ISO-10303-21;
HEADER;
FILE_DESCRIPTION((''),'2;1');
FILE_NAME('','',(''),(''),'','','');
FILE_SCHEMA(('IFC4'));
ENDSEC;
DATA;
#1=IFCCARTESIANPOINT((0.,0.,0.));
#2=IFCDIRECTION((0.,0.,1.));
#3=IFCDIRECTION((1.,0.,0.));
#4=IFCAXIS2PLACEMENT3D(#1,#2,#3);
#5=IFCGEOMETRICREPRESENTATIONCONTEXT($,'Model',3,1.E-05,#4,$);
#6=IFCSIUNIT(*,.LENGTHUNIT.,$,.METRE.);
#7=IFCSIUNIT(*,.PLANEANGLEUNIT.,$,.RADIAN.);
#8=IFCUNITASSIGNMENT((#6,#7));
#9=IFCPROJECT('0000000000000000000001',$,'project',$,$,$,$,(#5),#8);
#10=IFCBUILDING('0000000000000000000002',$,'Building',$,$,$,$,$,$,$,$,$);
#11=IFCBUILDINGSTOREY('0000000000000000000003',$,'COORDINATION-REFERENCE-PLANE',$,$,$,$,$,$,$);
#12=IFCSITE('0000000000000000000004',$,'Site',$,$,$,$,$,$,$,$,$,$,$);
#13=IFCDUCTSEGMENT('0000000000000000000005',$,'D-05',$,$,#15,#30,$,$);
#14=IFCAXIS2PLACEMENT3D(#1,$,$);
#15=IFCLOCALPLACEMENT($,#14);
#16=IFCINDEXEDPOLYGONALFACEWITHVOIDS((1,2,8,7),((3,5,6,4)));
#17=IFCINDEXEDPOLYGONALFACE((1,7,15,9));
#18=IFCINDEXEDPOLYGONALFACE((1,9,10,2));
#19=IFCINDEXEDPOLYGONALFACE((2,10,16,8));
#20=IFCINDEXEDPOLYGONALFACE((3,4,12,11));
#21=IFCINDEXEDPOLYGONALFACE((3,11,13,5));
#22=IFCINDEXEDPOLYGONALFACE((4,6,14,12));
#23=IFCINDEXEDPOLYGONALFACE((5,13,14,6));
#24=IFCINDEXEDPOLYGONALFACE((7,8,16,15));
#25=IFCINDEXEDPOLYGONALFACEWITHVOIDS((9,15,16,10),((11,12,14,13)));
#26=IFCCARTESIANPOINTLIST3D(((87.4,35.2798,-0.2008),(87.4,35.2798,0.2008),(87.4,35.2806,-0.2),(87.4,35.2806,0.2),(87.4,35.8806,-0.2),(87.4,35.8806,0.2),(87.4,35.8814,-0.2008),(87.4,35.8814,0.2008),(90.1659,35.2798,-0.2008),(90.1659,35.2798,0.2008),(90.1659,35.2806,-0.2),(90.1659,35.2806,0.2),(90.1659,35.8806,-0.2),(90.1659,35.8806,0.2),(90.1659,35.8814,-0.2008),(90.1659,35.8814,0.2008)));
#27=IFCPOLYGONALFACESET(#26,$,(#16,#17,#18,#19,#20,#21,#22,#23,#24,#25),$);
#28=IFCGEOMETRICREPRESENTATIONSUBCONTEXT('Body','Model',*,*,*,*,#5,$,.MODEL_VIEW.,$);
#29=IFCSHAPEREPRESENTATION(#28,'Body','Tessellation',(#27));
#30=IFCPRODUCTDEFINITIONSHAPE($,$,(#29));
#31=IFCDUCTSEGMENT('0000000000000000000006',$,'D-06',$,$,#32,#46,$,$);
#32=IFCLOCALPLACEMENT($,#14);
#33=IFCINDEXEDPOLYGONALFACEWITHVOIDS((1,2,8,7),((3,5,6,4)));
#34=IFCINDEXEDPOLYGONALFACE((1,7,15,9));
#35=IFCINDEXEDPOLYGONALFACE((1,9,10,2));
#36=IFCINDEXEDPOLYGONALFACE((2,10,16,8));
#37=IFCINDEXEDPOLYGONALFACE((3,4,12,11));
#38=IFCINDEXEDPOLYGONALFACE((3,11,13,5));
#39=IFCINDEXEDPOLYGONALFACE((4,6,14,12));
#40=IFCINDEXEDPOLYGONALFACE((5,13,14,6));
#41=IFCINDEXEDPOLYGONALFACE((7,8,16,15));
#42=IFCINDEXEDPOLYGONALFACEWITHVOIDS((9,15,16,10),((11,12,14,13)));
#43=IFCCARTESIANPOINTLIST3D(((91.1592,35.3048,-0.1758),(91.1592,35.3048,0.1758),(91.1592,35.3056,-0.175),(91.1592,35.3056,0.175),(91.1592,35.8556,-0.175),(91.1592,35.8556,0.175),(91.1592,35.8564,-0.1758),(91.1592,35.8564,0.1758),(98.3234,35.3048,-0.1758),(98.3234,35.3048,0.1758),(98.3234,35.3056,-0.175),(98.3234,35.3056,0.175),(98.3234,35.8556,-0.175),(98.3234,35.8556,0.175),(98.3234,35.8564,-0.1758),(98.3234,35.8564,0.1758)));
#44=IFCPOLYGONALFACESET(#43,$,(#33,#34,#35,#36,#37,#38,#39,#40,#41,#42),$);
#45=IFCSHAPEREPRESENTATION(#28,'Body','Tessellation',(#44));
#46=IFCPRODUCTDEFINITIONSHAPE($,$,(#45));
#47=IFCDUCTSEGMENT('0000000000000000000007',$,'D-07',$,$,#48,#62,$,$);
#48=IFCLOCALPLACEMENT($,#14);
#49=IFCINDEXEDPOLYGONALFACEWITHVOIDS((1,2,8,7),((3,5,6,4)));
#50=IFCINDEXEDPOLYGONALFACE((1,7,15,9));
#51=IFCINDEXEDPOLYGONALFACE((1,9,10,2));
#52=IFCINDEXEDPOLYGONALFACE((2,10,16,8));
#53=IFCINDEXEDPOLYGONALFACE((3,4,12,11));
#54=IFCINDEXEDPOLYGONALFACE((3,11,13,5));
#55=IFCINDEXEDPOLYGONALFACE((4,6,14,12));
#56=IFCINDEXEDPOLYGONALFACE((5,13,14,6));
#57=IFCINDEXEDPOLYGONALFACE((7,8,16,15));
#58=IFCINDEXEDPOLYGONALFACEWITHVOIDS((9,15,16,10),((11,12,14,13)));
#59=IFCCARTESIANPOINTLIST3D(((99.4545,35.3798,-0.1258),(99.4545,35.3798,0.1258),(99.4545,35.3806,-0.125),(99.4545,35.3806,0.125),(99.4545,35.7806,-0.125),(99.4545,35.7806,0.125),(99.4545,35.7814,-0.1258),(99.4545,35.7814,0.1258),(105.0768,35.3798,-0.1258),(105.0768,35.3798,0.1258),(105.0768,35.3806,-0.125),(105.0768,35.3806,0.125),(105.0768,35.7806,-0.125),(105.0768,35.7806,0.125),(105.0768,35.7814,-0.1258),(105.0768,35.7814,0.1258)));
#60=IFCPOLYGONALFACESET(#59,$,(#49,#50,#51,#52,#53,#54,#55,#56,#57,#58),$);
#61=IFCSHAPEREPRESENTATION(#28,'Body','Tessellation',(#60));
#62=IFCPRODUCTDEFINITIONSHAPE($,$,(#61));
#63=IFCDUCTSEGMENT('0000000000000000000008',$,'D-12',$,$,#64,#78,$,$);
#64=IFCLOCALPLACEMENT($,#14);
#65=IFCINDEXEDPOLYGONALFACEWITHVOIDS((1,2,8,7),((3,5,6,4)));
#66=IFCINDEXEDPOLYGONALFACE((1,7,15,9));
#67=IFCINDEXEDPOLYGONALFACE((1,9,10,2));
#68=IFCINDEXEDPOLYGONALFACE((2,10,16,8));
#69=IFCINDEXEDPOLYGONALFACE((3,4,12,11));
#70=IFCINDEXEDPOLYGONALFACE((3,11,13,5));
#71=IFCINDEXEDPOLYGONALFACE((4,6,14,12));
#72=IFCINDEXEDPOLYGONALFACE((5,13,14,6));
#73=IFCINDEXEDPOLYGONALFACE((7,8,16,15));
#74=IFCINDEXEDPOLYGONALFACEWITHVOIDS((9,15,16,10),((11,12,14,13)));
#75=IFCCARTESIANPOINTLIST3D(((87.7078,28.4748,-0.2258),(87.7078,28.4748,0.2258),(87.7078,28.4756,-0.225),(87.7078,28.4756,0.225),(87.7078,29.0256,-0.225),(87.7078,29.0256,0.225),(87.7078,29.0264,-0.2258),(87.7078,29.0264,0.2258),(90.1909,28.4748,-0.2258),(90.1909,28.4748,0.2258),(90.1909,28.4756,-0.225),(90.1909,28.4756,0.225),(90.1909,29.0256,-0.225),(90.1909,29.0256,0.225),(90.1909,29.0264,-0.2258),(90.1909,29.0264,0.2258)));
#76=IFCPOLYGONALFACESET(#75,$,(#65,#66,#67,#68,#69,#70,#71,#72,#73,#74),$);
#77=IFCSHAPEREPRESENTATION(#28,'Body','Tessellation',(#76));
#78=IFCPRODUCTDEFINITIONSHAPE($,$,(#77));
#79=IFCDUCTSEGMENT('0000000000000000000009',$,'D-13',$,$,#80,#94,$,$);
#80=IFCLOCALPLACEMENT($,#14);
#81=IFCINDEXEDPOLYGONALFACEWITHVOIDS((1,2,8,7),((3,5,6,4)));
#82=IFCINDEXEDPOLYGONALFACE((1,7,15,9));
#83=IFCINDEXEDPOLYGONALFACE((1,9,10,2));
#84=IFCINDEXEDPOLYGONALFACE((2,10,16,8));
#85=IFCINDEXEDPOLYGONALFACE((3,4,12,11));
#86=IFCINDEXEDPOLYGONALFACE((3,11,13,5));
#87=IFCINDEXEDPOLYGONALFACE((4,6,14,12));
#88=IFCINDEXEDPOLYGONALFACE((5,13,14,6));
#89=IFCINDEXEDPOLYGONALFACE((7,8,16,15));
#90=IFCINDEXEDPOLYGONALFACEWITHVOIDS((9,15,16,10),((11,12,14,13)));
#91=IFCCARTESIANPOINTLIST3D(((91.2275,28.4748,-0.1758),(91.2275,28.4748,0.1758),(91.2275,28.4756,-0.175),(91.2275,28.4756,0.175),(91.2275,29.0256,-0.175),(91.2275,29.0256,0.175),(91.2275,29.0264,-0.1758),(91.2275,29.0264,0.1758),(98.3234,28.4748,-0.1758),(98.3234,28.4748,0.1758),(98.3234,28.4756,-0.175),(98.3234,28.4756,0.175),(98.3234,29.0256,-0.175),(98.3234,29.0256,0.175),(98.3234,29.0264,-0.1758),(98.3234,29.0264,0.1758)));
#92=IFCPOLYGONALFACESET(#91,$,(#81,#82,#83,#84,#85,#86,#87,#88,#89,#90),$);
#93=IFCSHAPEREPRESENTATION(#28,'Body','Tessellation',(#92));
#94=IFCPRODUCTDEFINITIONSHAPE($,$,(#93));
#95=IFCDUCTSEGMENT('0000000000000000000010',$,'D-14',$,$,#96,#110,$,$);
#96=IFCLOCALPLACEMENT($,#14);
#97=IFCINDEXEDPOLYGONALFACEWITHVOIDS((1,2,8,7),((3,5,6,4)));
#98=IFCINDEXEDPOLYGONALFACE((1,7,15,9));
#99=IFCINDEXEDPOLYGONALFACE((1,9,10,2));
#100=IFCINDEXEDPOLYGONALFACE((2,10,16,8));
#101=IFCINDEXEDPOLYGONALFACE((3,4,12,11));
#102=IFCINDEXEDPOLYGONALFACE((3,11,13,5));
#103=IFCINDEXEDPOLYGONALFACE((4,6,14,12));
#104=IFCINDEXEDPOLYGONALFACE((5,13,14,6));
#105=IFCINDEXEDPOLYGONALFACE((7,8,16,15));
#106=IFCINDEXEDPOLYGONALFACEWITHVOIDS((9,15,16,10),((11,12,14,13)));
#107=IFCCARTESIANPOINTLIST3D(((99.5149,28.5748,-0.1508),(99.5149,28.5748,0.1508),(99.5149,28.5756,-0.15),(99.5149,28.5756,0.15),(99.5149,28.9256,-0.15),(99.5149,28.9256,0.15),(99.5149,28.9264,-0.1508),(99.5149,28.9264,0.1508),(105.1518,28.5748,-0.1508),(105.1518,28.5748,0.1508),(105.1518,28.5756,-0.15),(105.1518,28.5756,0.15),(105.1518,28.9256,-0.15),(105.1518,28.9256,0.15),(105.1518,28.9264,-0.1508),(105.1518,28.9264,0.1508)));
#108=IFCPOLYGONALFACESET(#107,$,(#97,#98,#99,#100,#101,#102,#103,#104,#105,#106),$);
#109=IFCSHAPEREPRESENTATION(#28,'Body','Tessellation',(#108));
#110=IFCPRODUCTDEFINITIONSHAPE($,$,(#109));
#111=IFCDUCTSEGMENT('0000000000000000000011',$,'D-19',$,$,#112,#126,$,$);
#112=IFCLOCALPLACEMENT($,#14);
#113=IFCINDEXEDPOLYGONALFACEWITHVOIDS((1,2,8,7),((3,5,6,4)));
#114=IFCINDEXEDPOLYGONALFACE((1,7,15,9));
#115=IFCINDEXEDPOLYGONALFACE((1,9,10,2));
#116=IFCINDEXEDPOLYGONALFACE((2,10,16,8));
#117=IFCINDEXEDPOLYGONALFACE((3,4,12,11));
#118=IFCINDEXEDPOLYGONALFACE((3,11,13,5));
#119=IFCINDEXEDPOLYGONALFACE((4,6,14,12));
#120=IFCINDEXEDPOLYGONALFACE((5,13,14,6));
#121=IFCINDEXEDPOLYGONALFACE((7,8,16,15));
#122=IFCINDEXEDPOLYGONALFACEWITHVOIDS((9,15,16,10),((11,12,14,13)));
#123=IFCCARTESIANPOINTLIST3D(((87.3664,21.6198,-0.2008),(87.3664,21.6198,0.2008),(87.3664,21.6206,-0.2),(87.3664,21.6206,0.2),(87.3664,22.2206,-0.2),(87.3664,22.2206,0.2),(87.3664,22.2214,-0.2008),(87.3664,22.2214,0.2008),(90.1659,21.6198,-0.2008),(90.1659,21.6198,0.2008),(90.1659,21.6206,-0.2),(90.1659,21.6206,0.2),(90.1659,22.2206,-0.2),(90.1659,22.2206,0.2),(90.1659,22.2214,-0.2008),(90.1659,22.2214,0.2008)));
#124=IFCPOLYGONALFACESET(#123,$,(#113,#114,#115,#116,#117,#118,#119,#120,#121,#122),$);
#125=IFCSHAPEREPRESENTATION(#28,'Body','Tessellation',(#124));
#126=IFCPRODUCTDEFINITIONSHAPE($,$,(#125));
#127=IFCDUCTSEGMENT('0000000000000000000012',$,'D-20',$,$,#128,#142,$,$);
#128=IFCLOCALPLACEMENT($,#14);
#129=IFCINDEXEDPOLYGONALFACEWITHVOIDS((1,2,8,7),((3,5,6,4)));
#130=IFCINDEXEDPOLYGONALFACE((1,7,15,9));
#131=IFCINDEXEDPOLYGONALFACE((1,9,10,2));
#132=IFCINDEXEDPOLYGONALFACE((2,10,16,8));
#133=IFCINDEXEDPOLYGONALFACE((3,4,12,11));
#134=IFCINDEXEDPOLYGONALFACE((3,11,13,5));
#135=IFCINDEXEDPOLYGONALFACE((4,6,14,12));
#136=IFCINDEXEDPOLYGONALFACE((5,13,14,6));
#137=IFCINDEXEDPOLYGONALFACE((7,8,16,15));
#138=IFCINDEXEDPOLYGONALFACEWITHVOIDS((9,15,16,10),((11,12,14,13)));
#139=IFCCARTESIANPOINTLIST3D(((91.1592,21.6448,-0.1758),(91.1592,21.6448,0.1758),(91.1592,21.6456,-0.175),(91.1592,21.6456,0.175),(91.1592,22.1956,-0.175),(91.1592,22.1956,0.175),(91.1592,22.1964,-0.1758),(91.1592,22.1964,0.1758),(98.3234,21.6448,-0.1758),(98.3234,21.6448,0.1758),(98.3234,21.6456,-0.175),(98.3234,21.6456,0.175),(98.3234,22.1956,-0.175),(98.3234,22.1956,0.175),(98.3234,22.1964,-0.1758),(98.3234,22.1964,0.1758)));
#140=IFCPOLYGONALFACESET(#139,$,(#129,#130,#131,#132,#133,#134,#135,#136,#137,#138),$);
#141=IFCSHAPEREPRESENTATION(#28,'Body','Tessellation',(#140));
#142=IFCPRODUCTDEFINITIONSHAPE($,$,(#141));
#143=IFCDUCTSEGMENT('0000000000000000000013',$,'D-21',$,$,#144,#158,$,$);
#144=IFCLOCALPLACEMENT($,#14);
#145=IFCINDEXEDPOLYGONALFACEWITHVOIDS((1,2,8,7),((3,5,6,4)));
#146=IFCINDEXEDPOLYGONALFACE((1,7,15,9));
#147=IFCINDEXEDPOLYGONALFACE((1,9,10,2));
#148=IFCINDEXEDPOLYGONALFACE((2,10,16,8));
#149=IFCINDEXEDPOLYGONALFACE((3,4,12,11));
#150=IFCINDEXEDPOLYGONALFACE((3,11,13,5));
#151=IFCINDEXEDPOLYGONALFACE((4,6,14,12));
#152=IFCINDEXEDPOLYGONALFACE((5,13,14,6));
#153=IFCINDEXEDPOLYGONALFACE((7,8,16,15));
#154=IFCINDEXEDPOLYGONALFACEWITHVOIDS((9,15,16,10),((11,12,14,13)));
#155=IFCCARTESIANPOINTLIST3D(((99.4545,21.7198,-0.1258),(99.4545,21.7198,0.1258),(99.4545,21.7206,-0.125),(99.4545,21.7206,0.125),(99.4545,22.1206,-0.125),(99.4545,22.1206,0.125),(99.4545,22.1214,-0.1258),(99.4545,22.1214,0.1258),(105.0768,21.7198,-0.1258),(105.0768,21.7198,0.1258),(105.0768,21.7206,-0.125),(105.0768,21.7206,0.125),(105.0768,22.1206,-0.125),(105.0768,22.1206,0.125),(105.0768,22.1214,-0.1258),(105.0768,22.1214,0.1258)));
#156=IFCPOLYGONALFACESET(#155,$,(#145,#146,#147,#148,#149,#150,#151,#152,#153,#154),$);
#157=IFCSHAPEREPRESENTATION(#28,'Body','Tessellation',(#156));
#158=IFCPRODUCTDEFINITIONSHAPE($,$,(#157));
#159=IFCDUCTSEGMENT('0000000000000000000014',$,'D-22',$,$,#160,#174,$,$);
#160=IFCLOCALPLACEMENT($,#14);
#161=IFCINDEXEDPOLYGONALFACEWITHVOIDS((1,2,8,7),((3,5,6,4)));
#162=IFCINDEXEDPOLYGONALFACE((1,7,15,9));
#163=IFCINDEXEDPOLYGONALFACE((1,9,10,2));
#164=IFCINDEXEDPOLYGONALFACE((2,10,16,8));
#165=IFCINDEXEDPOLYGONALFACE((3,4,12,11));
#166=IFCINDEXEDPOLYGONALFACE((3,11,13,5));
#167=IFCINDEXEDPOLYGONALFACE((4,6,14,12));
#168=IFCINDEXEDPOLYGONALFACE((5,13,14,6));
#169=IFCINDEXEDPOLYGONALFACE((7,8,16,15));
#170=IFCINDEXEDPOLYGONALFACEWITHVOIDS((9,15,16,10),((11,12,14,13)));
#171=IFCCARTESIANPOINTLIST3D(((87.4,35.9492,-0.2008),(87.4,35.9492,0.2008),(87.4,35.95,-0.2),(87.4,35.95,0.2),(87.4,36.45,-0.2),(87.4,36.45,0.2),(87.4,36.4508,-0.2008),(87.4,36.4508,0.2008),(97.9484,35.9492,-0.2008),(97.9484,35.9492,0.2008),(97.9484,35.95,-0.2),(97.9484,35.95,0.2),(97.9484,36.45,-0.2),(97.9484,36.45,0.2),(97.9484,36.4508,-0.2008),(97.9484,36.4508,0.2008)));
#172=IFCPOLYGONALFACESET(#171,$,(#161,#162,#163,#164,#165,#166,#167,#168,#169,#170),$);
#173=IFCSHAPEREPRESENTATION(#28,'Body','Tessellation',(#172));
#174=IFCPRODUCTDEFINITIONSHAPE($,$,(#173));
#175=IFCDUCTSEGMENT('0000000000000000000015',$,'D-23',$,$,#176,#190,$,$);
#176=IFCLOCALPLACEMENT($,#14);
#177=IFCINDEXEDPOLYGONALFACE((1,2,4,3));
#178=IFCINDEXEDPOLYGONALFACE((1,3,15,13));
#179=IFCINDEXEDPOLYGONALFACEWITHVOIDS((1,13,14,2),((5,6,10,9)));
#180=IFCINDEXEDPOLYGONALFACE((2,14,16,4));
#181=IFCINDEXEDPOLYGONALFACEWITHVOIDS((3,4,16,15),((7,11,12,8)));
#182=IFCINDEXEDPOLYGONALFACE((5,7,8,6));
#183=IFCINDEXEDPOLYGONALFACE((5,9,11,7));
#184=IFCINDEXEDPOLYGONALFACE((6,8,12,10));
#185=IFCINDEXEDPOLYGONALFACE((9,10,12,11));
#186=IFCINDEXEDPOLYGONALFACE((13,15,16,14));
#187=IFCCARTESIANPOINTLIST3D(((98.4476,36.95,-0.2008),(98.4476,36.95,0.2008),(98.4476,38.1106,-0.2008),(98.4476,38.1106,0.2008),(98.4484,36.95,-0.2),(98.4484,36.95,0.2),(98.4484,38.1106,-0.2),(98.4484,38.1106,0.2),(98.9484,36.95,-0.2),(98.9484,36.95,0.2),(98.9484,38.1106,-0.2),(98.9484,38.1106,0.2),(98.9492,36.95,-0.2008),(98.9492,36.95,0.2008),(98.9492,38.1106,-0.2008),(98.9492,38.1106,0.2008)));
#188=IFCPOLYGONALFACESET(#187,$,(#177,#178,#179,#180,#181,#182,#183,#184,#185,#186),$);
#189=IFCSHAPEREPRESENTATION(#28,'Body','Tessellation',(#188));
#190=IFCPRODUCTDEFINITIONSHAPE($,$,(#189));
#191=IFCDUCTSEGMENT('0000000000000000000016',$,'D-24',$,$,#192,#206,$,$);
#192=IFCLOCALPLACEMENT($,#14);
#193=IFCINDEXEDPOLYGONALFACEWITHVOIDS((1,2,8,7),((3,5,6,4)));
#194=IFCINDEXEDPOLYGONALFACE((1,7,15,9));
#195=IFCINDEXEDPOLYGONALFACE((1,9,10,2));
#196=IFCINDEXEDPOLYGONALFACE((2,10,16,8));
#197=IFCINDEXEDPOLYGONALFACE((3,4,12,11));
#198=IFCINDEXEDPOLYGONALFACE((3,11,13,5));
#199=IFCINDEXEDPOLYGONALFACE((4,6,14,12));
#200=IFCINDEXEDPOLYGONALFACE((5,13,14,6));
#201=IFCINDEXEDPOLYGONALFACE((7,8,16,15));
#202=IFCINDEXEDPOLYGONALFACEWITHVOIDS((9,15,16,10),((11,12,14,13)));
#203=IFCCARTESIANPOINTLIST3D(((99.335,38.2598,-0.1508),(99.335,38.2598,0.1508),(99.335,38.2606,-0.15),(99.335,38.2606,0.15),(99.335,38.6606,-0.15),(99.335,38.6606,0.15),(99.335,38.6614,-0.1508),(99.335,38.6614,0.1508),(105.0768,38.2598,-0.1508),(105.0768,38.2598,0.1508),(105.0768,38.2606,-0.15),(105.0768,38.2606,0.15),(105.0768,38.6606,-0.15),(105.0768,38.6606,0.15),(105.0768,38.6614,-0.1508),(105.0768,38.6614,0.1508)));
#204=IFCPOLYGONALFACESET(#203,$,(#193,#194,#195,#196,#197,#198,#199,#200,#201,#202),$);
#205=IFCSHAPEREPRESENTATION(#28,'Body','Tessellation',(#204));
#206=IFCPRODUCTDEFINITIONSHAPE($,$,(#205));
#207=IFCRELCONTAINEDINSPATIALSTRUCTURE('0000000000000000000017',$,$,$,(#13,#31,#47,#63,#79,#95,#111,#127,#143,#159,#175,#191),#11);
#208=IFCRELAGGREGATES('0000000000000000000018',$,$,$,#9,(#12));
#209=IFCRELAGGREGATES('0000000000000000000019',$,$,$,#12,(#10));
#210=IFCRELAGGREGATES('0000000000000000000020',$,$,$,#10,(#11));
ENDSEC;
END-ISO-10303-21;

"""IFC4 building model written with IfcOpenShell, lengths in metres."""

from ifc_helpers import new_model, si_unit, frame, origin, origin_with_axes, place, context, subcontext, project, spatial, hollow_rectangle, extrude, element, save


model = new_model("IFC4")

# Units and contexts
model_context = context("Model", 3, precision=1e-05, world=origin_with_axes())
body_context = subcontext(model_context, "Body", "Model", "MODEL_VIEW")
ifc_project = project(units=[si_unit("LENGTHUNIT", "METRE"), si_unit("PLANEANGLEUNIT", "RADIAN")], contexts=[model_context])

# Site, building, storey
site = spatial("IfcSite", under=ifc_project, Name="Site")
building = spatial("IfcBuilding", under=site, Name="Building")
storey = spatial("IfcBuildingStorey", under=building, Name="COORDINATION-REFERENCE-PLANE")

# Duct segments
duct_segment_1_placement = place(None, frame((87.4, 35.5806, 0.0), z_axis=(1.0, 0.0, 0.0), x_axis=(0.0, 1.0, 0.0)))
element("IfcDuctSegment", 1, at=duct_segment_1_placement, inside=storey, Name="D-05", context=body_context, shape_type="SweptSolid", body=[
    extrude(hollow_rectangle(XDim=0.6016, YDim=0.4016, WallThickness=0.0008), origin(), (0.0, 0.0, 1.0), 2.7659),
])
duct_segment_2_placement = place(None, frame((91.1592, 35.5806, 0.0), z_axis=(1.0, 0.0, 0.0), x_axis=(0.0, 1.0, 0.0)))
element("IfcDuctSegment", 2, at=duct_segment_2_placement, inside=storey, Name="D-06", context=body_context, shape_type="SweptSolid", body=[
    extrude(hollow_rectangle(XDim=0.5516, YDim=0.3516, WallThickness=0.0008), origin(), (0.0, 0.0, 1.0), 7.1642),
])
duct_segment_3_placement = place(None, frame((99.4545, 35.5806, 0.0), z_axis=(1.0, 0.0, 0.0), x_axis=(0.0, 1.0, 0.0)))
element("IfcDuctSegment", 3, at=duct_segment_3_placement, inside=storey, Name="D-07", context=body_context, shape_type="SweptSolid", body=[
    extrude(hollow_rectangle(XDim=0.4016, YDim=0.2516, WallThickness=0.0008), origin(), (0.0, 0.0, 1.0), 5.6223),
])
duct_segment_4_placement = place(None, frame((87.7078, 28.7506, 0.0), z_axis=(1.0, 0.0, 0.0), x_axis=(0.0, 1.0, 0.0)))
element("IfcDuctSegment", 4, at=duct_segment_4_placement, inside=storey, Name="D-12", context=body_context, shape_type="SweptSolid", body=[
    extrude(hollow_rectangle(XDim=0.5516, YDim=0.4516, WallThickness=0.0008), origin(), (0.0, 0.0, 1.0), 2.4831),
])
duct_segment_5_placement = place(None, frame((91.2275, 28.7506, 0.0), z_axis=(1.0, 0.0, 0.0), x_axis=(0.0, 1.0, 0.0)))
element("IfcDuctSegment", 5, at=duct_segment_5_placement, inside=storey, Name="D-13", context=body_context, shape_type="SweptSolid", body=[
    extrude(hollow_rectangle(XDim=0.5516, YDim=0.3516, WallThickness=0.0008), origin(), (0.0, 0.0, 1.0), 7.0959),
])
duct_segment_6_placement = place(None, frame((99.5149, 28.7506, 0.0), z_axis=(1.0, 0.0, 0.0), x_axis=(0.0, 1.0, 0.0)))
element("IfcDuctSegment", 6, at=duct_segment_6_placement, inside=storey, Name="D-14", context=body_context, shape_type="SweptSolid", body=[
    extrude(hollow_rectangle(XDim=0.3516, YDim=0.3016, WallThickness=0.0008), origin(), (0.0, 0.0, 1.0), 5.6369),
])
duct_segment_7_placement = place(None, frame((87.3664, 21.9206, 0.0), z_axis=(1.0, 0.0, 0.0), x_axis=(0.0, 1.0, 0.0)))
element("IfcDuctSegment", 7, at=duct_segment_7_placement, inside=storey, Name="D-19", context=body_context, shape_type="SweptSolid", body=[
    extrude(hollow_rectangle(XDim=0.6016, YDim=0.4016, WallThickness=0.0008), origin(), (0.0, 0.0, 1.0), 2.7995),
])
duct_segment_8_placement = place(None, frame((91.1592, 21.9206, 0.0), z_axis=(1.0, 0.0, 0.0), x_axis=(0.0, 1.0, 0.0)))
element("IfcDuctSegment", 8, at=duct_segment_8_placement, inside=storey, Name="D-20", context=body_context, shape_type="SweptSolid", body=[
    extrude(hollow_rectangle(XDim=0.5516, YDim=0.3516, WallThickness=0.0008), origin(), (0.0, 0.0, 1.0), 7.1642),
])
duct_segment_9_placement = place(None, frame((99.4545, 21.9206, 0.0), z_axis=(1.0, 0.0, 0.0), x_axis=(0.0, 1.0, 0.0)))
element("IfcDuctSegment", 9, at=duct_segment_9_placement, inside=storey, Name="D-21", context=body_context, shape_type="SweptSolid", body=[
    extrude(hollow_rectangle(XDim=0.4016, YDim=0.2516, WallThickness=0.0008), origin(), (0.0, 0.0, 1.0), 5.6223),
])
duct_segment_10_placement = place(None, frame((87.4, 36.2, 0.0), z_axis=(1.0, 0.0, 0.0), x_axis=(0.0, 1.0, 0.0)))
element("IfcDuctSegment", 10, at=duct_segment_10_placement, inside=storey, Name="D-22", context=body_context, shape_type="SweptSolid", body=[
    extrude(hollow_rectangle(XDim=0.5016, YDim=0.4016, WallThickness=0.0008), origin(), (0.0, 0.0, 1.0), 10.5484),
])
duct_segment_11_placement = place(None, frame((98.6984, 36.95, 0.0), z_axis=(0.0, 1.0, 0.0), x_axis=(1.0, 0.0, 0.0)))
element("IfcDuctSegment", 11, at=duct_segment_11_placement, inside=storey, Name="D-23", context=body_context, shape_type="SweptSolid", body=[
    extrude(hollow_rectangle(XDim=0.5016, YDim=0.4016, WallThickness=0.0008), origin(), (0.0, 0.0, 1.0), 1.1606),
])
duct_segment_12_placement = place(None, frame((99.335, 38.4606, 0.0), z_axis=(1.0, 0.0, 0.0), x_axis=(0.0, 1.0, 0.0)))
element("IfcDuctSegment", 12, at=duct_segment_12_placement, inside=storey, Name="D-24", context=body_context, shape_type="SweptSolid", body=[
    extrude(hollow_rectangle(XDim=0.4016, YDim=0.3016, WallThickness=0.0008), origin(), (0.0, 0.0, 1.0), 5.7417),
])

save(model, "model.ifc")
